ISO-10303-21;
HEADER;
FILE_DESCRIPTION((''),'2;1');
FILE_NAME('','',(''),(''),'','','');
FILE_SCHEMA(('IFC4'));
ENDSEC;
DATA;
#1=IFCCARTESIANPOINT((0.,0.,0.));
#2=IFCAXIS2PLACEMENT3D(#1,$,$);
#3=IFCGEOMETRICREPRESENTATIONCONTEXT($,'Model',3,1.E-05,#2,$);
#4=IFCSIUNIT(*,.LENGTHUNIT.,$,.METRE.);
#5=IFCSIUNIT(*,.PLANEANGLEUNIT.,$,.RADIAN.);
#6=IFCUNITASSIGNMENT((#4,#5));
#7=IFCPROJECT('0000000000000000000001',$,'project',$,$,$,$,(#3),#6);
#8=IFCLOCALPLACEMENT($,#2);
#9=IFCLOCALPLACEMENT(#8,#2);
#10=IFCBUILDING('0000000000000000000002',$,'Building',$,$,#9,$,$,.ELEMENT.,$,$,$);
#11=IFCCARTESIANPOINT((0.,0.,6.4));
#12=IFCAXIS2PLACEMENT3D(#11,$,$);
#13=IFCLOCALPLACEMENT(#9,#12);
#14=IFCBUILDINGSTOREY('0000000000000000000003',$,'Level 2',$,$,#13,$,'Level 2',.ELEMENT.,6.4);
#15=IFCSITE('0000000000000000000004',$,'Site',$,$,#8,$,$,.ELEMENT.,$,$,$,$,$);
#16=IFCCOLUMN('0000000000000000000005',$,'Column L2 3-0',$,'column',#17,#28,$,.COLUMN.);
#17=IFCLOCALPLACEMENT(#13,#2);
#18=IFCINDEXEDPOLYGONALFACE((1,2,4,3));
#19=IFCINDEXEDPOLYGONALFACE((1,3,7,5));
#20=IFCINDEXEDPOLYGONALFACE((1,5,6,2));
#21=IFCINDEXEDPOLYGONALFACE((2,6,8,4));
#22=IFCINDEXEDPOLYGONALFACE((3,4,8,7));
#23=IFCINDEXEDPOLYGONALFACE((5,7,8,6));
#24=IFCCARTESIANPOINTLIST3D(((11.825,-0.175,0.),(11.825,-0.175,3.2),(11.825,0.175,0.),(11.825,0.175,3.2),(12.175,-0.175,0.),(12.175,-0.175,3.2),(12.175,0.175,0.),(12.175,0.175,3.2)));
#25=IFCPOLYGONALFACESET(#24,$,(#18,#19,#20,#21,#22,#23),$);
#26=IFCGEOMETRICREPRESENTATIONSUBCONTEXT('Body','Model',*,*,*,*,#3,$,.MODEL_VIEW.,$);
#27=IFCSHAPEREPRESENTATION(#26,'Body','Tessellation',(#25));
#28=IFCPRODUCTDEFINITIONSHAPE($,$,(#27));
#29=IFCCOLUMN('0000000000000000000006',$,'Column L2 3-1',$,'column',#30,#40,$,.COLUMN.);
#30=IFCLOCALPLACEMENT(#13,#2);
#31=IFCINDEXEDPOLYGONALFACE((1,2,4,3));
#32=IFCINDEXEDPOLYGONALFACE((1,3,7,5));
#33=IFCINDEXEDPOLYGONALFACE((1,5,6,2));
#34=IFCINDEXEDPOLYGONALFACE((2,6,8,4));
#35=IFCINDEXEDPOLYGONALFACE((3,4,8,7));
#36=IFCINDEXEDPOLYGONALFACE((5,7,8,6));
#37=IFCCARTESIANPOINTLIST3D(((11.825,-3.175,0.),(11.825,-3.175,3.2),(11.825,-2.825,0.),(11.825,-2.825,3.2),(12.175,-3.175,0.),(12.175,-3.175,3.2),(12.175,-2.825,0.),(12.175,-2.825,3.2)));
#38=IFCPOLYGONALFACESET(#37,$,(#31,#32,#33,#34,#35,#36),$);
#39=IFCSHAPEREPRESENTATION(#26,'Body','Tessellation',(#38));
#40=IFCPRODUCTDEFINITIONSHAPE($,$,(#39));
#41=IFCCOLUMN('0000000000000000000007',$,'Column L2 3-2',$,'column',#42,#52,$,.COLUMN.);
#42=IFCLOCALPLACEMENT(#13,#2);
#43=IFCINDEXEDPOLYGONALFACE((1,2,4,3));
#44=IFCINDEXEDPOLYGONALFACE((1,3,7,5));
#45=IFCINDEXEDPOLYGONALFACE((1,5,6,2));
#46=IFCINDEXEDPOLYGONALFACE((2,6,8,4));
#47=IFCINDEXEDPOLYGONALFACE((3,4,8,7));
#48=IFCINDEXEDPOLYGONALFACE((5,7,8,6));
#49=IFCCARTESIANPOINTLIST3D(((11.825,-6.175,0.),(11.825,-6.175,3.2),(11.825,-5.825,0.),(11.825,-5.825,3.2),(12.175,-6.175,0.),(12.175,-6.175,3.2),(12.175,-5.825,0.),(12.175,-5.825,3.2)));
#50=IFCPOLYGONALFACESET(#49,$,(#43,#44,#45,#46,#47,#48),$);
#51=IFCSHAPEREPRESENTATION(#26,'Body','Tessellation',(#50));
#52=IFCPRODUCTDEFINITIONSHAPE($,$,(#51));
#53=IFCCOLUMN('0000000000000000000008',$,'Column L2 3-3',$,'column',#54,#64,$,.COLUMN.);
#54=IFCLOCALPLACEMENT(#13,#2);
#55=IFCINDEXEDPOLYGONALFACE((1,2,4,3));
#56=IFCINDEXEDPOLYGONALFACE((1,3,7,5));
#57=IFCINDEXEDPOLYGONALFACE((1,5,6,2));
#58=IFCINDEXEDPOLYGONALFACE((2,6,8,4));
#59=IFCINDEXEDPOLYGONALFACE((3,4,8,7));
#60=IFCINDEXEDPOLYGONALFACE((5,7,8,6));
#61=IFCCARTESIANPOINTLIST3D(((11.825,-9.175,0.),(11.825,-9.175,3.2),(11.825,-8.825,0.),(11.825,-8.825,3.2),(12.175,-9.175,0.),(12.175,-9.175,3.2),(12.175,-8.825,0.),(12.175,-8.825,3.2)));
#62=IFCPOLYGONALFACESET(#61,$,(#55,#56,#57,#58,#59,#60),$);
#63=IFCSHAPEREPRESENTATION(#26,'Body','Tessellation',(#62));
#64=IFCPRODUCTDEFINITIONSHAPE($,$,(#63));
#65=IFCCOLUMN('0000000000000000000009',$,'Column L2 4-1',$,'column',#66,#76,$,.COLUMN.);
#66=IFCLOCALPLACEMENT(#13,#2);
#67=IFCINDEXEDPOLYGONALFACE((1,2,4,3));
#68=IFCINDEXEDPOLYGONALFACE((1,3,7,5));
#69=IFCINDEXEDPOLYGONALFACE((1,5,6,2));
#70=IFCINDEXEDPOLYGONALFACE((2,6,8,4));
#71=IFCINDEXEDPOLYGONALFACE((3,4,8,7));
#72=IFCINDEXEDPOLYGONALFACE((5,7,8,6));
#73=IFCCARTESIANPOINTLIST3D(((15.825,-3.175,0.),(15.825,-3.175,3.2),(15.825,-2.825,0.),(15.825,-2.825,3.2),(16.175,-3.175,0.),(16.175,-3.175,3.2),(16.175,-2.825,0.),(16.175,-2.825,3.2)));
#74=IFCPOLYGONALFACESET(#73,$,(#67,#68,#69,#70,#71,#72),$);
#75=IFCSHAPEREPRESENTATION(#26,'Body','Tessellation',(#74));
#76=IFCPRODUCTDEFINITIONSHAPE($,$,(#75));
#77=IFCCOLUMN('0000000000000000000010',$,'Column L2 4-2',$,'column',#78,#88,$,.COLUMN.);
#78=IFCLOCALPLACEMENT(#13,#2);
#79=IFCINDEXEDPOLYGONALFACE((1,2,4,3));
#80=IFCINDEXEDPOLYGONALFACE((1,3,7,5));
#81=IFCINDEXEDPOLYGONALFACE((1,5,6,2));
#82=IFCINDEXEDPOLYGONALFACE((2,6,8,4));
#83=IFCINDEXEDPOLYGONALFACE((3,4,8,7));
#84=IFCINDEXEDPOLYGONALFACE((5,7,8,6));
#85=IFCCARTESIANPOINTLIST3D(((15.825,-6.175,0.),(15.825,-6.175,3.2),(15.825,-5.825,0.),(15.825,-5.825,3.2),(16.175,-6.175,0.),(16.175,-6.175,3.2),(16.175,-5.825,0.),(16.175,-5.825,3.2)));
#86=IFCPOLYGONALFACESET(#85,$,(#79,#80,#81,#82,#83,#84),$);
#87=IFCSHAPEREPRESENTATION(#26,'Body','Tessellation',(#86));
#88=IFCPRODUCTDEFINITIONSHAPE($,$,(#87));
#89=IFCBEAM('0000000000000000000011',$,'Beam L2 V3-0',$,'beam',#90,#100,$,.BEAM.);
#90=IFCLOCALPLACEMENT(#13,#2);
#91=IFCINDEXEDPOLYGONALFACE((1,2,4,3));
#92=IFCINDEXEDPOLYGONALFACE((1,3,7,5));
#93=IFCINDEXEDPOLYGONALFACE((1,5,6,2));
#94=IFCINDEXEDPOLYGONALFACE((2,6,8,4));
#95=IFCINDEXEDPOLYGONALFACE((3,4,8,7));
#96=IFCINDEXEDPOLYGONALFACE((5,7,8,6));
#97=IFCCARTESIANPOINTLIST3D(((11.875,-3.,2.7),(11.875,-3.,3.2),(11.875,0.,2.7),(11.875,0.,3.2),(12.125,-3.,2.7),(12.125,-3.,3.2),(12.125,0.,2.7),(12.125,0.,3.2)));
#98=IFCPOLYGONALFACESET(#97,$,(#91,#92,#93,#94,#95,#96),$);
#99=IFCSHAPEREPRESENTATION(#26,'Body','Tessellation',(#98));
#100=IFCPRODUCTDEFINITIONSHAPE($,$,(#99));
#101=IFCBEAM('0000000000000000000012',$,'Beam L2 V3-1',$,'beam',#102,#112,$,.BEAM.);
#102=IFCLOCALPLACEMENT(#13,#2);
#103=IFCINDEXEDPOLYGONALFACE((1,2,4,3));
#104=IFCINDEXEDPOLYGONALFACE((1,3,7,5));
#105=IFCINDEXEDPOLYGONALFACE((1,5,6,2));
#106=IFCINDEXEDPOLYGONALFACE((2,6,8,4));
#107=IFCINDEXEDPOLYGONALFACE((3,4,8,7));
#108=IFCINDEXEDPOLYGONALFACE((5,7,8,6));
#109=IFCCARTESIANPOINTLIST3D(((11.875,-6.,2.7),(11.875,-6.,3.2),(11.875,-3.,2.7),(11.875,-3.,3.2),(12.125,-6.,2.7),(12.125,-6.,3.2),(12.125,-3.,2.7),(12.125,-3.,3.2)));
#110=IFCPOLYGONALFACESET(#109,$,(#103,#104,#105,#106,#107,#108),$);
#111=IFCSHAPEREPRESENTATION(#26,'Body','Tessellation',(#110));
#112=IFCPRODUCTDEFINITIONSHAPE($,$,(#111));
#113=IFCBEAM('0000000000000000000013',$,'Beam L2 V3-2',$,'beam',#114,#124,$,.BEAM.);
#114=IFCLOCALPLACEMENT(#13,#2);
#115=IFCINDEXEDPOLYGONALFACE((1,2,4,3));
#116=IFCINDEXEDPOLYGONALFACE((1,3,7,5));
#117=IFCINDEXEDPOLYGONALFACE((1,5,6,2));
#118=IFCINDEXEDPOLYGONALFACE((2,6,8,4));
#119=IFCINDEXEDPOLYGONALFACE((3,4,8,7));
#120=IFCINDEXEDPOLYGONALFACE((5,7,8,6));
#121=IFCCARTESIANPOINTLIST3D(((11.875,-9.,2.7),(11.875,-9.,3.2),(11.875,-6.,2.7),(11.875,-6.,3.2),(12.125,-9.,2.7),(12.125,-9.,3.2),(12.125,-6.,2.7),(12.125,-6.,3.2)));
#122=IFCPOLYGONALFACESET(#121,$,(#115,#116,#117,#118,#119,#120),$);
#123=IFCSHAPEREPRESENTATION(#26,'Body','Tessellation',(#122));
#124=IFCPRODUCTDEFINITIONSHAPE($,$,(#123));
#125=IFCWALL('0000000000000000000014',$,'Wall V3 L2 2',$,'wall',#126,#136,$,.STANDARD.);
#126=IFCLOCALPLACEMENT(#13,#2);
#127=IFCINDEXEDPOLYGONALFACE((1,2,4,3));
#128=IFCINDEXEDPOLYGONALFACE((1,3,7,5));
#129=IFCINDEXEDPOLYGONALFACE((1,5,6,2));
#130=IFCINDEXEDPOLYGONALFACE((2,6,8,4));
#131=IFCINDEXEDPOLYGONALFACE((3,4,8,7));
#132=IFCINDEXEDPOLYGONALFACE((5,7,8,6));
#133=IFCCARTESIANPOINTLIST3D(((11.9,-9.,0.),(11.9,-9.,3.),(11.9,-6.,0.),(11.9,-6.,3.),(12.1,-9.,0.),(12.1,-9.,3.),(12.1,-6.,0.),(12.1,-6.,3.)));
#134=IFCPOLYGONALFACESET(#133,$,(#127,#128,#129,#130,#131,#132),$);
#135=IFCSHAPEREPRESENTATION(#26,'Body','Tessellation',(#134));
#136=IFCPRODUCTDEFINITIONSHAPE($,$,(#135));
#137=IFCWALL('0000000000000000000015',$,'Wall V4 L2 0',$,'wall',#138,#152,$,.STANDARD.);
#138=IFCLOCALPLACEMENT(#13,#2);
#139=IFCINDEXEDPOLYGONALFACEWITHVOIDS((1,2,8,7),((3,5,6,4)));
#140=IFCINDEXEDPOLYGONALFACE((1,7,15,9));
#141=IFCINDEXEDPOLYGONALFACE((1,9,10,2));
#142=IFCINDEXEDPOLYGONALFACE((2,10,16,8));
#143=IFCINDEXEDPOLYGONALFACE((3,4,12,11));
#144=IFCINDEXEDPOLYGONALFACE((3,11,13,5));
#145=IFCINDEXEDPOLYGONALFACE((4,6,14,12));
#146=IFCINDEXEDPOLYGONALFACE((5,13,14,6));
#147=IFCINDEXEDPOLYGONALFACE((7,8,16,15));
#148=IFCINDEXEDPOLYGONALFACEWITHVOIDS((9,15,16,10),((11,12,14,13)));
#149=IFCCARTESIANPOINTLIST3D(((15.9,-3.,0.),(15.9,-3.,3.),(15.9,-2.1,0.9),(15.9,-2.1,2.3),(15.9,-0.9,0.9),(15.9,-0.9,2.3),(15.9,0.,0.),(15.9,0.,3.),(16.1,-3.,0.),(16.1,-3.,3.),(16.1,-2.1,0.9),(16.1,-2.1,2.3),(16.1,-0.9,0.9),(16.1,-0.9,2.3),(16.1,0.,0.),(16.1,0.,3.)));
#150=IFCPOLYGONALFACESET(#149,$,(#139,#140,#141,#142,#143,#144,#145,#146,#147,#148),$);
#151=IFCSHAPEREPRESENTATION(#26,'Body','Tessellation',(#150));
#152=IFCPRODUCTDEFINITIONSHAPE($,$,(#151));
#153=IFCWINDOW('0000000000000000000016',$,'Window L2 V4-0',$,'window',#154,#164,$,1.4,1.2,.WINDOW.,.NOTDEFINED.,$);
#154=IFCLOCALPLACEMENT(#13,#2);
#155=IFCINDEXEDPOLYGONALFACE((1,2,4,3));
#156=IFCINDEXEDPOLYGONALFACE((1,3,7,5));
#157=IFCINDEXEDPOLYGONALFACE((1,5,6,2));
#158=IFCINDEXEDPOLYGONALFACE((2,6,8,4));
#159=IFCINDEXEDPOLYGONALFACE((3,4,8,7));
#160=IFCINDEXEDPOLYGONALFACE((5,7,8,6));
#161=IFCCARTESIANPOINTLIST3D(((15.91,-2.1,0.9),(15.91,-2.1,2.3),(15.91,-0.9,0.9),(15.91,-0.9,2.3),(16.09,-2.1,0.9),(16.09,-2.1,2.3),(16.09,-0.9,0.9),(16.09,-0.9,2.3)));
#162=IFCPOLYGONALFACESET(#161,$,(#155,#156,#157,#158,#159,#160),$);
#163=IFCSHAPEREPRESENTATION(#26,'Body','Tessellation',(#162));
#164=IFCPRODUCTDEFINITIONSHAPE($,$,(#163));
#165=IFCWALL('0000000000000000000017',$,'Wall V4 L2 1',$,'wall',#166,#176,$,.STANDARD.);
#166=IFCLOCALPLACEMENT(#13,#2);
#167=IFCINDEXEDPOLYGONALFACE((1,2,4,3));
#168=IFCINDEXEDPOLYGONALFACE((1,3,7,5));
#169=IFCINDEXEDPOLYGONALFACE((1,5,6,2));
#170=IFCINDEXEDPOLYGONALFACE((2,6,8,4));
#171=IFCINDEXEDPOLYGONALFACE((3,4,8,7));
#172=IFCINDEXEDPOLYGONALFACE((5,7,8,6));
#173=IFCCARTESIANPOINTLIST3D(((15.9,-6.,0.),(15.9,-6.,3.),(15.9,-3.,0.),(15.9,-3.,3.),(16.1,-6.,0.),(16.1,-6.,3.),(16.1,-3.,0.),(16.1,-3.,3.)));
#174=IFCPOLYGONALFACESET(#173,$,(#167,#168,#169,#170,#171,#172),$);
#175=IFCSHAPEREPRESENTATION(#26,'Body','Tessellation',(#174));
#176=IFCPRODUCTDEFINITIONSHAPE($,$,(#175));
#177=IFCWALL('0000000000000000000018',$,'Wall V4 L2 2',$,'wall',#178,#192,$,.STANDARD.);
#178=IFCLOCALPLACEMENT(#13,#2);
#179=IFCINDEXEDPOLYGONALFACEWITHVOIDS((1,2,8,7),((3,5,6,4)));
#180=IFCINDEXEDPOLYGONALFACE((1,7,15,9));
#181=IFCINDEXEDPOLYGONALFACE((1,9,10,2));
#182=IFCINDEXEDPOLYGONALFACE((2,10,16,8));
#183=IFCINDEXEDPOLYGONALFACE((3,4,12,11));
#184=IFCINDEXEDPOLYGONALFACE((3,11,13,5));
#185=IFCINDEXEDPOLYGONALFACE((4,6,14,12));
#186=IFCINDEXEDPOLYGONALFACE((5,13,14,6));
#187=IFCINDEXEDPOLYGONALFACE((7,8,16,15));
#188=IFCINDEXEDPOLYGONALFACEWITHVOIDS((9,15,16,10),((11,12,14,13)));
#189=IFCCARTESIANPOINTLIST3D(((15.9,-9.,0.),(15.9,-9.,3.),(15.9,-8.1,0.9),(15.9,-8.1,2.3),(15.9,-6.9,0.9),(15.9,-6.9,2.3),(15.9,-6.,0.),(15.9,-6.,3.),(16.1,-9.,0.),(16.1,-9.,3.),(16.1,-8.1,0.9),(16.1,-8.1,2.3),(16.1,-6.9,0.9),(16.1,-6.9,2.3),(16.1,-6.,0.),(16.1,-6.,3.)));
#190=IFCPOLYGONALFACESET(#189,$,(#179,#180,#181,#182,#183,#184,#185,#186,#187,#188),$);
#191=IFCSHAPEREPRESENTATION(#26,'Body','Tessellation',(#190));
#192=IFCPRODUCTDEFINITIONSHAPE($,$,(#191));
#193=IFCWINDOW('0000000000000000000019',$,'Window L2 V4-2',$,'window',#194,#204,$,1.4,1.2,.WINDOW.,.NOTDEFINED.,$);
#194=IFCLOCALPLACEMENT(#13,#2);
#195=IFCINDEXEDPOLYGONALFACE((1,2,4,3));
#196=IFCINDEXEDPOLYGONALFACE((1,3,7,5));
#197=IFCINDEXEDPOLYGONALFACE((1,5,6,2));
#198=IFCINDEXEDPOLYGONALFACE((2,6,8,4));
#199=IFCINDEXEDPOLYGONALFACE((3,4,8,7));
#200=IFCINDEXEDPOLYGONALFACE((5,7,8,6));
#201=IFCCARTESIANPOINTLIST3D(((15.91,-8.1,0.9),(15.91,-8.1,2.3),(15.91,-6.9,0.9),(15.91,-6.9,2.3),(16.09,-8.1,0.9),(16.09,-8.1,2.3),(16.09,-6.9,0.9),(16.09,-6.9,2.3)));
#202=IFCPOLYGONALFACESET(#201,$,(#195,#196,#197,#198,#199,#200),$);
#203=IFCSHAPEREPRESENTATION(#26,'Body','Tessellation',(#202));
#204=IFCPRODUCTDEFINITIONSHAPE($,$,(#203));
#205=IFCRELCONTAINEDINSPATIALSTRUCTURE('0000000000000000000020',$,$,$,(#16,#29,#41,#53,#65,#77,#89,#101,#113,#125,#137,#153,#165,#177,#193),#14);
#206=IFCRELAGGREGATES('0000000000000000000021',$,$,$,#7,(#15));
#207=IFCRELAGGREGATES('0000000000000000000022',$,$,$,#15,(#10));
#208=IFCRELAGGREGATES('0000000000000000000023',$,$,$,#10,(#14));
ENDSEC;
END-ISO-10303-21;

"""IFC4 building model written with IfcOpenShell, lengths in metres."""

from ifc_helpers import new_model, si_unit, frame, frame_2d, origin, origin_2d, place, context, subcontext, project, spatial, rectangle, extrude, element, fill, save


model = new_model("IFC4")

# Units and contexts
model_context = context("Model", 3, precision=1e-05, world=origin())
body_context = subcontext(model_context, "Body", "Model", "MODEL_VIEW")
ifc_project = project(units=[si_unit("LENGTHUNIT", "METRE"), si_unit("PLANEANGLEUNIT", "RADIAN")], contexts=[model_context])

# Site, building, storey
site_placement = place(None, origin())
site = spatial("IfcSite", under=ifc_project, at=site_placement, Name="Site", CompositionType="ELEMENT")
building_placement = place(site_placement, origin())
building = spatial("IfcBuilding", under=site, at=building_placement, Name="Building", CompositionType="ELEMENT")
storey_placement = place(building_placement, frame((0.0, 0.0, 6.4)))
storey = spatial("IfcBuildingStorey", under=building, at=storey_placement, Name="Level 2", LongName="Level 2", CompositionType="ELEMENT", Elevation=6.4)

# Columns
for number, where, name in (
    (1, (12.0, 0.0, 0.0), "Column L2 3-0"),
    (2, (12.0, -3.0, 0.0), "Column L2 3-1"),
    (3, (12.0, -6.0, 0.0), "Column L2 3-2"),
    (4, (12.0, -9.0, 0.0), "Column L2 3-3"),
    (5, (16.0, -3.0, 0.0), "Column L2 4-1"),
    (6, (16.0, -6.0, 0.0), "Column L2 4-2"),
):
    element("IfcColumn", number, at=place(storey_placement, frame(where)), inside=storey, Name=name, ObjectType="column", PredefinedType="COLUMN", context=body_context, shape_type="SweptSolid", body=[
        extrude(rectangle(XDim=0.35, YDim=0.35, at=origin_2d()), origin(), (0.0, 0.0, 1.0), 3.2),
    ])

# Beams
for number, where, z_axis, x_axis, name in (
    (7, (12.0, 0.0, 2.95), (0.0, -1.0, 0.0), (0.0, 0.0, 1.0), "Beam L2 V3-0"),
    (8, (12.0, -3.0, 2.95), (0.0, -1.0, 0.0), (0.0, 0.0, 1.0), "Beam L2 V3-1"),
    (9, (12.0, -6.0, 2.95), (0.0, -1.0, 0.0), (0.0, 0.0, 1.0), "Beam L2 V3-2"),
):
    element("IfcBeam", number, at=place(storey_placement, frame(where, z_axis=z_axis, x_axis=x_axis)), inside=storey, Name=name, ObjectType="beam", PredefinedType="BEAM", context=body_context, shape_type="SweptSolid", body=[
        extrude(rectangle(XDim=0.5, YDim=0.25, at=origin_2d()), origin(), (0.0, 0.0, 1.0), 3.0),
    ])

# Wall
wall_1_placement = place(storey_placement, frame((12.0, -6.0, 0.0), z_axis=(0.0, 0.0, 1.0), x_axis=(0.0, -1.0, 0.0)))
element("IfcWall", 10, at=wall_1_placement, inside=storey, Name="Wall V3 L2 2", ObjectType="wall", PredefinedType="STANDARD", context=body_context, shape_type="SweptSolid", body=[
    extrude(rectangle(XDim=3.0, YDim=0.2, at=frame_2d((1.5, 0.0))), origin(), (0.0, 0.0, 1.0), 3.0),
])

# Wall, opening, window
wall_2_placement = place(storey_placement, frame((16.0, 0.0, 0.0), z_axis=(0.0, 0.0, 1.0), x_axis=(0.0, -1.0, 0.0)))
wall_2 = element("IfcWall", 11, at=wall_2_placement, inside=storey, Name="Wall V4 L2 0", ObjectType="wall", PredefinedType="STANDARD", context=body_context, shape_type="SweptSolid", body=[
    extrude(rectangle(XDim=3.0, YDim=0.2, at=frame_2d((1.5, 0.0))), origin(), (0.0, 0.0, 1.0), 3.0),
])
opening_1_placement = place(storey_placement, frame((16.0, -1.5, 0.9), z_axis=(0.0, 0.0, 1.0), x_axis=(0.0, -1.0, 0.0)))
opening_1 = element("IfcOpeningElement", 12, at=opening_1_placement, cuts=wall_2, ObjectType="Opening", PredefinedType="OPENING", context=body_context, shape_type="SweptSolid", body=[
    extrude(rectangle(XDim=1.2, YDim=0.22, at=origin_2d()), origin(), (0.0, 0.0, 1.0), 1.4),
])
window_1_placement = place(storey_placement, frame((16.0, -1.5, 0.9), z_axis=(0.0, 0.0, 1.0), x_axis=(0.0, -1.0, 0.0)))
window_1 = element("IfcWindow", 13, at=window_1_placement, inside=storey, Name="Window L2 V4-0", ObjectType="window", OverallHeight=1.4, OverallWidth=1.2, PartitioningType="NOTDEFINED", PredefinedType="WINDOW", context=body_context, shape_type="SweptSolid", body=[
    extrude(rectangle(XDim=1.2, YDim=0.18, at=origin_2d()), origin(), (0.0, 0.0, 1.0), 1.4),
])
fill(opening_1, window_1)

# Wall
wall_3_placement = place(storey_placement, frame((16.0, -3.0, 0.0), z_axis=(0.0, 0.0, 1.0), x_axis=(0.0, -1.0, 0.0)))
element("IfcWall", 14, at=wall_3_placement, inside=storey, Name="Wall V4 L2 1", ObjectType="wall", PredefinedType="STANDARD", context=body_context, shape_type="SweptSolid", body=[
    extrude(rectangle(XDim=3.0, YDim=0.2, at=frame_2d((1.5, 0.0))), origin(), (0.0, 0.0, 1.0), 3.0),
])

# Wall, opening, window
wall_4_placement = place(storey_placement, frame((16.0, -6.0, 0.0), z_axis=(0.0, 0.0, 1.0), x_axis=(0.0, -1.0, 0.0)))
wall_4 = element("IfcWall", 15, at=wall_4_placement, inside=storey, Name="Wall V4 L2 2", ObjectType="wall", PredefinedType="STANDARD", context=body_context, shape_type="SweptSolid", body=[
    extrude(rectangle(XDim=3.0, YDim=0.2, at=frame_2d((1.5, 0.0))), origin(), (0.0, 0.0, 1.0), 3.0),
])
opening_2_placement = place(storey_placement, frame((16.0, -7.5, 0.9), z_axis=(0.0, 0.0, 1.0), x_axis=(0.0, -1.0, 0.0)))
opening_2 = element("IfcOpeningElement", 16, at=opening_2_placement, cuts=wall_4, ObjectType="Opening", PredefinedType="OPENING", context=body_context, shape_type="SweptSolid", body=[
    extrude(rectangle(XDim=1.2, YDim=0.22, at=origin_2d()), origin(), (0.0, 0.0, 1.0), 1.4),
])
window_2_placement = place(storey_placement, frame((16.0, -7.5, 0.9), z_axis=(0.0, 0.0, 1.0), x_axis=(0.0, -1.0, 0.0)))
window_2 = element("IfcWindow", 17, at=window_2_placement, inside=storey, Name="Window L2 V4-2", ObjectType="window", OverallHeight=1.4, OverallWidth=1.2, PartitioningType="NOTDEFINED", PredefinedType="WINDOW", context=body_context, shape_type="SweptSolid", body=[
    extrude(rectangle(XDim=1.2, YDim=0.18, at=origin_2d()), origin(), (0.0, 0.0, 1.0), 1.4),
])
fill(opening_2, window_2)

save(model, "model.ifc")
